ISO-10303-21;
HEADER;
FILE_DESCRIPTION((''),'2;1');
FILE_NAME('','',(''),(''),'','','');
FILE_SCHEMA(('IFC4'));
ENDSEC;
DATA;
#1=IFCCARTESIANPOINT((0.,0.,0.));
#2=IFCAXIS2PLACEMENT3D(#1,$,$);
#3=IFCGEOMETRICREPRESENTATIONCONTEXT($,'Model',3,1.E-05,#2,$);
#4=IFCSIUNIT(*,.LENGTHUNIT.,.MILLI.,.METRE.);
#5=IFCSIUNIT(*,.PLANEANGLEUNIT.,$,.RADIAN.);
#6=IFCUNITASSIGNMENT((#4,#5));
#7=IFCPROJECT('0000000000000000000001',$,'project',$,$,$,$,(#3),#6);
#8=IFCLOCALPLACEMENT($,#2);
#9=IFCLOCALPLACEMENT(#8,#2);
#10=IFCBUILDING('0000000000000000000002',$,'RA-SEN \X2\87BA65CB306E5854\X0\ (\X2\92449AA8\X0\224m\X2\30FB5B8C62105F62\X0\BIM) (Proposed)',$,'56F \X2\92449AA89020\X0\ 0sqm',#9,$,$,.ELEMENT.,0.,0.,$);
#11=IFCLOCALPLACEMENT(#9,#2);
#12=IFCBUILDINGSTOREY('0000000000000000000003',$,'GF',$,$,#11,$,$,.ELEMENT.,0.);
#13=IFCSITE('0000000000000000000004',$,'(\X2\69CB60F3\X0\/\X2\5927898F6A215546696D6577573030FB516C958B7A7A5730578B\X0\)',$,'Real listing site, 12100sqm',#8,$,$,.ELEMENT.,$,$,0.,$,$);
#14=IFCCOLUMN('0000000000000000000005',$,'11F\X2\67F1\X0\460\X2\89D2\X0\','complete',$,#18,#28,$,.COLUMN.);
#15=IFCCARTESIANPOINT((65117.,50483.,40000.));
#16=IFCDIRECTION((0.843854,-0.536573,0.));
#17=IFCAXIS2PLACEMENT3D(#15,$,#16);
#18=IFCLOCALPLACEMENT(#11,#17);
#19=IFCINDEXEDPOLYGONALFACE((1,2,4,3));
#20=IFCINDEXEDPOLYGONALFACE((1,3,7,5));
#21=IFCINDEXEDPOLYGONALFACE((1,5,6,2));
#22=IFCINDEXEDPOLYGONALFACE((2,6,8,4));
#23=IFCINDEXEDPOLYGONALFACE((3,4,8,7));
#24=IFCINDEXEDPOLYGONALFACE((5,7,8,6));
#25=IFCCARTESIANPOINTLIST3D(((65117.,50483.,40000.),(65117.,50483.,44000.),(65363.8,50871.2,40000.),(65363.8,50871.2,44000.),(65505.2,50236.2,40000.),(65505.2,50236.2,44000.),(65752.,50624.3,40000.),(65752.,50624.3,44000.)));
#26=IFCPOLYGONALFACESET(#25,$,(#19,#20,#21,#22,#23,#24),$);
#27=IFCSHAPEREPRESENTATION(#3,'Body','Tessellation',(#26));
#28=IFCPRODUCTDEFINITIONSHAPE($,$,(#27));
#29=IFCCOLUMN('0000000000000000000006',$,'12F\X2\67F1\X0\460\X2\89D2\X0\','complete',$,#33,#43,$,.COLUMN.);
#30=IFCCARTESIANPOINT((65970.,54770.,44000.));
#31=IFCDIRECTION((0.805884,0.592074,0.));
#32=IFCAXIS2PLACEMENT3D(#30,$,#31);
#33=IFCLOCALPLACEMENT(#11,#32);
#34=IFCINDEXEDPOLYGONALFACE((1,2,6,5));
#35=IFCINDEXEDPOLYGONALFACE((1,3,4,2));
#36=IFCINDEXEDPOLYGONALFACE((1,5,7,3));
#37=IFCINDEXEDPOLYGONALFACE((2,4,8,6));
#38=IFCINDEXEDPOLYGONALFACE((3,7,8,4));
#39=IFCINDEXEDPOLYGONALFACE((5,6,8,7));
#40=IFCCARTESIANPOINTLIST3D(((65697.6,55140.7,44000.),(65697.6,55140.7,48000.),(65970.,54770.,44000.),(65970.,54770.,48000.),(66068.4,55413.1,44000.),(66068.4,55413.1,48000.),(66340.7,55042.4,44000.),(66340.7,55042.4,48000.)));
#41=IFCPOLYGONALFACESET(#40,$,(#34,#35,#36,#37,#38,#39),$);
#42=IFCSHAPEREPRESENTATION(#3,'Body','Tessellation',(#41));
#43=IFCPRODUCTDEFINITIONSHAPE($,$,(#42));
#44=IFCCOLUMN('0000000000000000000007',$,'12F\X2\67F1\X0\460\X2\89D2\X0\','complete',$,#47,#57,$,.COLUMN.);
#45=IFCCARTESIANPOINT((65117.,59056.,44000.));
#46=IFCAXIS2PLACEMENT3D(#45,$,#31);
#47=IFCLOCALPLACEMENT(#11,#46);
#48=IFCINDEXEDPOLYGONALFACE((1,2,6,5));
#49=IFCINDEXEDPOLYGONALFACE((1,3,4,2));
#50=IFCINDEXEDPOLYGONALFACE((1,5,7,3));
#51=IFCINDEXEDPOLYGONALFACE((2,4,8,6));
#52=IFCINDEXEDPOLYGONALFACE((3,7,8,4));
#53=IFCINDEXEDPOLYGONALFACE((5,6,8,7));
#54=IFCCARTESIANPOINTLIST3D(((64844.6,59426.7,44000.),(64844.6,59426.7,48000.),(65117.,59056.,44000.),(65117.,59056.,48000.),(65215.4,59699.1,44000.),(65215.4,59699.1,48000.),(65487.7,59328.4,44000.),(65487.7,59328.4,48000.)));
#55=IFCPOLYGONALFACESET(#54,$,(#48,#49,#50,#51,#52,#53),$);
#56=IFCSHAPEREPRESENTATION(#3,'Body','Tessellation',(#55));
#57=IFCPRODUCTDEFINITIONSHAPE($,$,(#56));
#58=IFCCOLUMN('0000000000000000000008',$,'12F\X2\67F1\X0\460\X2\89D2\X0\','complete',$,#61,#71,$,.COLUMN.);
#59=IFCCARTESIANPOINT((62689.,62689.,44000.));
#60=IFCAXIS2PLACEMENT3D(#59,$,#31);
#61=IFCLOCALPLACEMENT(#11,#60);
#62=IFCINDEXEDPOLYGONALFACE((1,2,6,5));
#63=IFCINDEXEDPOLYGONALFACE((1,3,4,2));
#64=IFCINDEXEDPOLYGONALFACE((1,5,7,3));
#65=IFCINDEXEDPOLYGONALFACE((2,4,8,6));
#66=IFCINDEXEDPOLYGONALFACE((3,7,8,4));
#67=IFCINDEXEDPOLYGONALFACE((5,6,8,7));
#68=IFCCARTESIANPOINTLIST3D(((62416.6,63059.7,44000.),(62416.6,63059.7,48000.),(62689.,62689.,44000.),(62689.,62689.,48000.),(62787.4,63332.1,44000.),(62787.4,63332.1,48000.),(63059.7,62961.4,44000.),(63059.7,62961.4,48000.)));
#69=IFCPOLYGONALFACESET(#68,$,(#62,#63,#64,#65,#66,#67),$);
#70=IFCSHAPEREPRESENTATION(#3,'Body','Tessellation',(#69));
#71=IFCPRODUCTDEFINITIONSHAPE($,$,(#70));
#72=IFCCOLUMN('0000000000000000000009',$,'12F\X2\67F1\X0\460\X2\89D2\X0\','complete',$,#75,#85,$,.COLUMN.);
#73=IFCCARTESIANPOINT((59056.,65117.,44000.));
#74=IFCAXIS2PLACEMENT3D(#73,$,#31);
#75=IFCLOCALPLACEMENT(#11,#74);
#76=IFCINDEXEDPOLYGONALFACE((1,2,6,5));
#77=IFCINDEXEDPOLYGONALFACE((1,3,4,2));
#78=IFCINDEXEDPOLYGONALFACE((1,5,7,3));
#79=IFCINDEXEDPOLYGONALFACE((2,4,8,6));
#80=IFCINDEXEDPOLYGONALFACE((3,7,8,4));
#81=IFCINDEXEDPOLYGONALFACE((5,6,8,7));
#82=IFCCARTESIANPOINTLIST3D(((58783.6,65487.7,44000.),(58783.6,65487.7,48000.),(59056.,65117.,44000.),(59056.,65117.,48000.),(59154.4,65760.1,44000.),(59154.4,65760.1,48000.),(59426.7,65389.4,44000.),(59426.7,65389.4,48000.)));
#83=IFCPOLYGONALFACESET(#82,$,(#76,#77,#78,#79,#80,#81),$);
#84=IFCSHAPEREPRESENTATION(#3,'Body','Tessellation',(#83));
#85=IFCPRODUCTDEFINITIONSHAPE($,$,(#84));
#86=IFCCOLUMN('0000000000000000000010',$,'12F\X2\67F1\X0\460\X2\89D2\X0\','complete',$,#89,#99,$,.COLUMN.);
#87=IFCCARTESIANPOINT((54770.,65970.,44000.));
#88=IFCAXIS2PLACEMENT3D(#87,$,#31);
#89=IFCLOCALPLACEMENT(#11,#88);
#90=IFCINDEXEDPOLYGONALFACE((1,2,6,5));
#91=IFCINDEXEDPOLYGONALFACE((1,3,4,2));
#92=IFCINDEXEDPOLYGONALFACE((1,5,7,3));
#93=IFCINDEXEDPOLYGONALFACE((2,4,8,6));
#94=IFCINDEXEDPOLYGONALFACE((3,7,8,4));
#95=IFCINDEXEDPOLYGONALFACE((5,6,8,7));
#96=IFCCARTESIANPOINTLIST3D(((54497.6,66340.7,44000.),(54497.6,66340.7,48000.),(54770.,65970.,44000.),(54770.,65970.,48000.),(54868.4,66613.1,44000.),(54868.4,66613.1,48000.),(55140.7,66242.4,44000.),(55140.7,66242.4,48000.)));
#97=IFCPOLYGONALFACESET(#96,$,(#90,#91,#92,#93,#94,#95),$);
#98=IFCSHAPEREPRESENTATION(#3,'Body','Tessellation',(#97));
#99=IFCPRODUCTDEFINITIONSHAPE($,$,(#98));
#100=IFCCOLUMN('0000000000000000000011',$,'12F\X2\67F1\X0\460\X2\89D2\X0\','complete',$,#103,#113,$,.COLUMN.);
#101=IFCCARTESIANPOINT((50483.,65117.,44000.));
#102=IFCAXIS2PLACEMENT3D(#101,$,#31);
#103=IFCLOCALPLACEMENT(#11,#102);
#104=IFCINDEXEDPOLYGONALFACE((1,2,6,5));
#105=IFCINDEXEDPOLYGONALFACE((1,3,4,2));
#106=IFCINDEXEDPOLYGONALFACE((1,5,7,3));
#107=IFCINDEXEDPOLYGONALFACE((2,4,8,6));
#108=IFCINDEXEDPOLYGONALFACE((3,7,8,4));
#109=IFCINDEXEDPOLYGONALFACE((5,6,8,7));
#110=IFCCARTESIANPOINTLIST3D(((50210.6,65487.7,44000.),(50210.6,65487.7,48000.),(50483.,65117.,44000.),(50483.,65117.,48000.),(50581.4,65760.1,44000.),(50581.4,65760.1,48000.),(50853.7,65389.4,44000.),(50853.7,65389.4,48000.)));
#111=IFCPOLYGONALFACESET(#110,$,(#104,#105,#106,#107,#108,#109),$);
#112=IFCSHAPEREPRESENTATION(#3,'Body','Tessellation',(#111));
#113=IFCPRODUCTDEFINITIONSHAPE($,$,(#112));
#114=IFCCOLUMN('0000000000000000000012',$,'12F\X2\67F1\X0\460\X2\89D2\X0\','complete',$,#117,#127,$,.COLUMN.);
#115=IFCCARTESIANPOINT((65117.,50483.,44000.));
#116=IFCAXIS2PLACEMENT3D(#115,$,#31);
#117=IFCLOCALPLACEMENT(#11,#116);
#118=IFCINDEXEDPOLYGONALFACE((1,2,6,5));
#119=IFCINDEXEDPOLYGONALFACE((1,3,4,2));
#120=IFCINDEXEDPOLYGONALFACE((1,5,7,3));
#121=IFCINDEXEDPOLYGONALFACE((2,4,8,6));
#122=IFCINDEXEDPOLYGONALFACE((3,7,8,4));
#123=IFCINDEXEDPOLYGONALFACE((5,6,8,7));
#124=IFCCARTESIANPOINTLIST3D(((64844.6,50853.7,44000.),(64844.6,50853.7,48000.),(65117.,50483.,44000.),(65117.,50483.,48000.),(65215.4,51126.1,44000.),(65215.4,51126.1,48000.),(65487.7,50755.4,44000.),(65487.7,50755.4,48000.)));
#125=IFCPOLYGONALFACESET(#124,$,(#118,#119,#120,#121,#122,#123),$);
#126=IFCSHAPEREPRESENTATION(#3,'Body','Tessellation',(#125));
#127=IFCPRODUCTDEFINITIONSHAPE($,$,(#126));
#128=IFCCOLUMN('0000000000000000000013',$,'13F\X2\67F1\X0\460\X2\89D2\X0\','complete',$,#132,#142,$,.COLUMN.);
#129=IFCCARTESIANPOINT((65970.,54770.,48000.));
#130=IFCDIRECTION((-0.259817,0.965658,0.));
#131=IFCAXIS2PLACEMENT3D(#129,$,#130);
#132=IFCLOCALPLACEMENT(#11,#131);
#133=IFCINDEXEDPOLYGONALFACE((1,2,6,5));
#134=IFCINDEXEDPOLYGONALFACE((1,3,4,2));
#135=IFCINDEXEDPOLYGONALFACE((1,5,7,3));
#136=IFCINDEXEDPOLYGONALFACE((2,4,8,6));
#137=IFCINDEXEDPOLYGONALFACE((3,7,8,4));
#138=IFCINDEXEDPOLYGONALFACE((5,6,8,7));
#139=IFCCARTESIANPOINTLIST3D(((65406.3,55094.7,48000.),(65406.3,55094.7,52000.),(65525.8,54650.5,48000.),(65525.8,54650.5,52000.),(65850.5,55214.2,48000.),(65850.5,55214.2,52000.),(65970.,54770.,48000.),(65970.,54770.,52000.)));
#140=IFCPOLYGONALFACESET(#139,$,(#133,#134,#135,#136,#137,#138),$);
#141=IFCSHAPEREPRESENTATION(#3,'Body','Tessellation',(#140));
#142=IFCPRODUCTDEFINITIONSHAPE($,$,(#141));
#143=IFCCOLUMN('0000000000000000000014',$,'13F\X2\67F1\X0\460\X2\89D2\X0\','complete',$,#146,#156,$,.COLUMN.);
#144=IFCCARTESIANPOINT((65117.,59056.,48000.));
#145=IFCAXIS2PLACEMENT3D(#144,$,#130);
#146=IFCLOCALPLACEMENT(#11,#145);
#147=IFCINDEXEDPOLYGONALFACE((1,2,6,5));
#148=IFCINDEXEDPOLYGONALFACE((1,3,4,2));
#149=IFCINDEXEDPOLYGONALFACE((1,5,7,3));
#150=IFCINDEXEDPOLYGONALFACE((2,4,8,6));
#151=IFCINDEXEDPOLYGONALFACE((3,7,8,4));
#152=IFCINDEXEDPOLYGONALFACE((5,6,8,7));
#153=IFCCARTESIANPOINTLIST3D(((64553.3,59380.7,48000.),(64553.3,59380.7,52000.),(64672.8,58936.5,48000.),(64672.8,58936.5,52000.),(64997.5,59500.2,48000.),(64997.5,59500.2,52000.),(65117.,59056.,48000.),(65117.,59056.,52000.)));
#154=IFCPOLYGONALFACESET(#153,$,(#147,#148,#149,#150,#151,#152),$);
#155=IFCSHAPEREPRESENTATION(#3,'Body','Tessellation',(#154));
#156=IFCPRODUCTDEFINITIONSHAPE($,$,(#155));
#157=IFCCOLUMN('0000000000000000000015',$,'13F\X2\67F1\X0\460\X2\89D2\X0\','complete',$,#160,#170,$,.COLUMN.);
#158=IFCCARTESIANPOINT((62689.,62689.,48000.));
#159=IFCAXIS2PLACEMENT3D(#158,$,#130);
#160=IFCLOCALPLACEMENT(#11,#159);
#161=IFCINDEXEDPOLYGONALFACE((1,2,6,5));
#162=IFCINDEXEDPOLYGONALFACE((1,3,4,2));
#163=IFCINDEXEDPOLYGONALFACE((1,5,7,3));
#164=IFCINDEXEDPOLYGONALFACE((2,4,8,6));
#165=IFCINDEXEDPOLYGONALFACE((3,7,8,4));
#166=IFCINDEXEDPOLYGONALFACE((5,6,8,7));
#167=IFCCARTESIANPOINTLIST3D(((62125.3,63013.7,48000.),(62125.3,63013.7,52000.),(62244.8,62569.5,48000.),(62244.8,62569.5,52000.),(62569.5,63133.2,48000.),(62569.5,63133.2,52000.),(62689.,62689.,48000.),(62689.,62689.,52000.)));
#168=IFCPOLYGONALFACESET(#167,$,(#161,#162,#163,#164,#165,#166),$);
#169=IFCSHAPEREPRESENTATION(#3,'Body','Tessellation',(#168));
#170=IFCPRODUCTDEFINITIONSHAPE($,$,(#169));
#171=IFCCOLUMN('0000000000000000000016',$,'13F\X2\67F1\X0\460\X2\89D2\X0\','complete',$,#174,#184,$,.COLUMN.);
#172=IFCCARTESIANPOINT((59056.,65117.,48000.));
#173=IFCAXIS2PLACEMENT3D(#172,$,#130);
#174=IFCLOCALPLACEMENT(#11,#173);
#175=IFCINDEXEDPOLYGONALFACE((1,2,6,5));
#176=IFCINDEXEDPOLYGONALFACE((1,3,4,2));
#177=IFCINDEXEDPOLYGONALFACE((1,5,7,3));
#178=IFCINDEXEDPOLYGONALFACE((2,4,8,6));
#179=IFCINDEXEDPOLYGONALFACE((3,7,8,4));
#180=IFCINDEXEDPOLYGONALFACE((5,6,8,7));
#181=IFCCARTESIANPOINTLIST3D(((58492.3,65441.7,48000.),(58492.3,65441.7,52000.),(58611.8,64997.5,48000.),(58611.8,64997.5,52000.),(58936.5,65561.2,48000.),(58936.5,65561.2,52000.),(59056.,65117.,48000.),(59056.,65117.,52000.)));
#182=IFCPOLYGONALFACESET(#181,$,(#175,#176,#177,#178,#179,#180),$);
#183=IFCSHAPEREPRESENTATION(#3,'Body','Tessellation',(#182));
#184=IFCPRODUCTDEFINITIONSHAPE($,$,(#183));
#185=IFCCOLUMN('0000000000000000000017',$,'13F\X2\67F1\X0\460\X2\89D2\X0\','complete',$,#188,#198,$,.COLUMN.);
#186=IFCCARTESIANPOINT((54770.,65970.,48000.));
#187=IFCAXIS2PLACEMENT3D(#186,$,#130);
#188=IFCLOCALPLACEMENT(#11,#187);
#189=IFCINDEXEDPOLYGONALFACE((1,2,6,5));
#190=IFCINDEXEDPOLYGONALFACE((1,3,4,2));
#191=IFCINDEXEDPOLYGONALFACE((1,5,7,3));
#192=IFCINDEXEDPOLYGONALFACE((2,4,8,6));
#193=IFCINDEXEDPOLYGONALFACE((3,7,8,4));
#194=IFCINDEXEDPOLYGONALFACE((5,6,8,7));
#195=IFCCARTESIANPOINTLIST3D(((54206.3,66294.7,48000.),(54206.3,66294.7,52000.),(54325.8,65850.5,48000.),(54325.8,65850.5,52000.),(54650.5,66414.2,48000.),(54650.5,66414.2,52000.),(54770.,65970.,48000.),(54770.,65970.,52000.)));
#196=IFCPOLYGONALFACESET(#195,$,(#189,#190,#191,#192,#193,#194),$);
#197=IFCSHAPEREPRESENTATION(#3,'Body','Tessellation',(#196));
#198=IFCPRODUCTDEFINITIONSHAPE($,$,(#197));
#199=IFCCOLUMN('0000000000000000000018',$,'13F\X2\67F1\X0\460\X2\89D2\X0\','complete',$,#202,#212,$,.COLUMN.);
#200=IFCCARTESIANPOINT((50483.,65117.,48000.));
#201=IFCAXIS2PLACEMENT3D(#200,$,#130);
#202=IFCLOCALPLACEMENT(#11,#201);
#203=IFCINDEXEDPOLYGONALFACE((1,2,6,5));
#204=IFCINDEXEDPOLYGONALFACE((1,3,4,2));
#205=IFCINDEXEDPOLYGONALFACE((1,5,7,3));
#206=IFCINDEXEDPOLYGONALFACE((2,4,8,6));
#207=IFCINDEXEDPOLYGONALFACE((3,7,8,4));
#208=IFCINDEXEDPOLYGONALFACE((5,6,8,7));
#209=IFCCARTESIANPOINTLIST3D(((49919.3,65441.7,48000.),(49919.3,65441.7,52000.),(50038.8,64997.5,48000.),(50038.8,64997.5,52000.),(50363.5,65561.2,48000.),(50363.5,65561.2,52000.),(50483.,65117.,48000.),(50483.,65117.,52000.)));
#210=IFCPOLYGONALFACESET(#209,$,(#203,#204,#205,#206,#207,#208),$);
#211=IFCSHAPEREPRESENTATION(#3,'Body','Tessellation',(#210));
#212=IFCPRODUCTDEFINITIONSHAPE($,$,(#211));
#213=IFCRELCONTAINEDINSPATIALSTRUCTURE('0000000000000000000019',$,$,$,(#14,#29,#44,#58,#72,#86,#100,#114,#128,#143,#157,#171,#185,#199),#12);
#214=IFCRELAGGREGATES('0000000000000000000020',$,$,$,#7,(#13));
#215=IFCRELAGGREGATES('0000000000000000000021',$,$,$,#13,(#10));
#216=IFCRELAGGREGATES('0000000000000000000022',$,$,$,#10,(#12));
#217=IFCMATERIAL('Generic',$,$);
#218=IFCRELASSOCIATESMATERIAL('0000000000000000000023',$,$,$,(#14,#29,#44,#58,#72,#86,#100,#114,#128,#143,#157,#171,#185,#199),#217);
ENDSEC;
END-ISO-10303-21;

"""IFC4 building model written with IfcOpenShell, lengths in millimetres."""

from ifc_helpers import new_model, si_unit, frame, frame_2d, origin, place, context, project, spatial, rectangle, extrude, material, element, save


model = new_model("IFC4")

# Units and contexts
model_context = context("Model", 3, precision=1e-05, world=origin())
ifc_project = project(units=[si_unit("LENGTHUNIT", "METRE", prefix="MILLI"), si_unit("PLANEANGLEUNIT", "RADIAN")], contexts=[model_context])

# Site, building, storey
site_placement = place(None, origin())
site = spatial("IfcSite", under=ifc_project, at=site_placement, Name="(構想/大規模商業敷地・公開空地型)", ObjectType="Real listing site, 12100sqm", CompositionType="ELEMENT", RefElevation=0.0)
building_placement = place(site_placement, origin())
building = spatial("IfcBuilding", under=site, at=building_placement, Name="RA-SEN 螺旋の塔 (鉄骨224m・完成形BIM) (Proposed)", ObjectType="56F 鉄骨造 0sqm", CompositionType="ELEMENT", ElevationOfRefHeight=0.0, ElevationOfTerrain=0.0)
storey_placement = place(building_placement, origin())
storey = spatial("IfcBuildingStorey", under=building, at=storey_placement, Name="GF", CompositionType="ELEMENT", Elevation=0.0)

# Columns
ifc_material = material(Name="Generic")
column_1_placement = place(storey_placement, frame((65117.0, 50483.0, 40000.0), x_axis=(0.843854, -0.536573, 0.0)))
element("IfcColumn", 1, at=column_1_placement, inside=storey, material=ifc_material, Name="11F柱460角", Description="complete", PredefinedType="COLUMN", context=model_context, shape_type="SweptSolid", body=[
    extrude(rectangle(XDim=460.0, YDim=460.0, at=frame_2d((230.0, 230.0))), frame((65117.0, 50483.0, 40000.0), x_axis=(0.843854, -0.536573, 0.0)), (0.0, 0.0, 1.0), 4000.0),
])
column_2_placement = place(storey_placement, frame((65970.0, 54770.0, 44000.0), x_axis=(0.805884, 0.592074, 0.0)))
element("IfcColumn", 2, at=column_2_placement, inside=storey, material=ifc_material, Name="12F柱460角", Description="complete", PredefinedType="COLUMN", context=model_context, shape_type="SweptSolid", body=[
    extrude(rectangle(XDim=460.0, YDim=460.0, at=frame_2d((230.0, 230.0))), frame((65970.0, 54770.0, 44000.0), x_axis=(0.805884, 0.592074, 0.0)), (0.0, 0.0, 1.0), 4000.0),
])
column_3_placement = place(storey_placement, frame((65117.0, 59056.0, 44000.0), x_axis=(0.805884, 0.592074, 0.0)))
element("IfcColumn", 3, at=column_3_placement, inside=storey, material=ifc_material, Name="12F柱460角", Description="complete", PredefinedType="COLUMN", context=model_context, shape_type="SweptSolid", body=[
    extrude(rectangle(XDim=460.0, YDim=460.0, at=frame_2d((230.0, 230.0))), frame((65117.0, 59056.0, 44000.0), x_axis=(0.805884, 0.592074, 0.0)), (0.0, 0.0, 1.0), 4000.0),
])
column_4_placement = place(storey_placement, frame((62689.0, 62689.0, 44000.0), x_axis=(0.805884, 0.592074, 0.0)))
element("IfcColumn", 4, at=column_4_placement, inside=storey, material=ifc_material, Name="12F柱460角", Description="complete", PredefinedType="COLUMN", context=model_context, shape_type="SweptSolid", body=[
    extrude(rectangle(XDim=460.0, YDim=460.0, at=frame_2d((230.0, 230.0))), frame((62689.0, 62689.0, 44000.0), x_axis=(0.805884, 0.592074, 0.0)), (0.0, 0.0, 1.0), 4000.0),
])
column_5_placement = place(storey_placement, frame((59056.0, 65117.0, 44000.0), x_axis=(0.805884, 0.592074, 0.0)))
element("IfcColumn", 5, at=column_5_placement, inside=storey, material=ifc_material, Name="12F柱460角", Description="complete", PredefinedType="COLUMN", context=model_context, shape_type="SweptSolid", body=[
    extrude(rectangle(XDim=460.0, YDim=460.0, at=frame_2d((230.0, 230.0))), frame((59056.0, 65117.0, 44000.0), x_axis=(0.805884, 0.592074, 0.0)), (0.0, 0.0, 1.0), 4000.0),
])
column_6_placement = place(storey_placement, frame((54770.0, 65970.0, 44000.0), x_axis=(0.805884, 0.592074, 0.0)))
element("IfcColumn", 6, at=column_6_placement, inside=storey, material=ifc_material, Name="12F柱460角", Description="complete", PredefinedType="COLUMN", context=model_context, shape_type="SweptSolid", body=[
    extrude(rectangle(XDim=460.0, YDim=460.0, at=frame_2d((230.0, 230.0))), frame((54770.0, 65970.0, 44000.0), x_axis=(0.805884, 0.592074, 0.0)), (0.0, 0.0, 1.0), 4000.0),
])
column_7_placement = place(storey_placement, frame((50483.0, 65117.0, 44000.0), x_axis=(0.805884, 0.592074, 0.0)))
element("IfcColumn", 7, at=column_7_placement, inside=storey, material=ifc_material, Name="12F柱460角", Description="complete", PredefinedType="COLUMN", context=model_context, shape_type="SweptSolid", body=[
    extrude(rectangle(XDim=460.0, YDim=460.0, at=frame_2d((230.0, 230.0))), frame((50483.0, 65117.0, 44000.0), x_axis=(0.805884, 0.592074, 0.0)), (0.0, 0.0, 1.0), 4000.0),
])
column_8_placement = place(storey_placement, frame((65117.0, 50483.0, 44000.0), x_axis=(0.805884, 0.592074, 0.0)))
element("IfcColumn", 8, at=column_8_placement, inside=storey, material=ifc_material, Name="12F柱460角", Description="complete", PredefinedType="COLUMN", context=model_context, shape_type="SweptSolid", body=[
    extrude(rectangle(XDim=460.0, YDim=460.0, at=frame_2d((230.0, 230.0))), frame((65117.0, 50483.0, 44000.0), x_axis=(0.805884, 0.592074, 0.0)), (0.0, 0.0, 1.0), 4000.0),
])
column_9_placement = place(storey_placement, frame((65970.0, 54770.0, 48000.0), x_axis=(-0.259817, 0.965658, 0.0)))
element("IfcColumn", 9, at=column_9_placement, inside=storey, material=ifc_material, Name="13F柱460角", Description="complete", PredefinedType="COLUMN", context=model_context, shape_type="SweptSolid", body=[
    extrude(rectangle(XDim=460.0, YDim=460.0, at=frame_2d((230.0, 230.0))), frame((65970.0, 54770.0, 48000.0), x_axis=(-0.259817, 0.965658, 0.0)), (0.0, 0.0, 1.0), 4000.0),
])
column_10_placement = place(storey_placement, frame((65117.0, 59056.0, 48000.0), x_axis=(-0.259817, 0.965658, 0.0)))
element("IfcColumn", 10, at=column_10_placement, inside=storey, material=ifc_material, Name="13F柱460角", Description="complete", PredefinedType="COLUMN", context=model_context, shape_type="SweptSolid", body=[
    extrude(rectangle(XDim=460.0, YDim=460.0, at=frame_2d((230.0, 230.0))), frame((65117.0, 59056.0, 48000.0), x_axis=(-0.259817, 0.965658, 0.0)), (0.0, 0.0, 1.0), 4000.0),
])
column_11_placement = place(storey_placement, frame((62689.0, 62689.0, 48000.0), x_axis=(-0.259817, 0.965658, 0.0)))
element("IfcColumn", 11, at=column_11_placement, inside=storey, material=ifc_material, Name="13F柱460角", Description="complete", PredefinedType="COLUMN", context=model_context, shape_type="SweptSolid", body=[
    extrude(rectangle(XDim=460.0, YDim=460.0, at=frame_2d((230.0, 230.0))), frame((62689.0, 62689.0, 48000.0), x_axis=(-0.259817, 0.965658, 0.0)), (0.0, 0.0, 1.0), 4000.0),
])
column_12_placement = place(storey_placement, frame((59056.0, 65117.0, 48000.0), x_axis=(-0.259817, 0.965658, 0.0)))
element("IfcColumn", 12, at=column_12_placement, inside=storey, material=ifc_material, Name="13F柱460角", Description="complete", PredefinedType="COLUMN", context=model_context, shape_type="SweptSolid", body=[
    extrude(rectangle(XDim=460.0, YDim=460.0, at=frame_2d((230.0, 230.0))), frame((59056.0, 65117.0, 48000.0), x_axis=(-0.259817, 0.965658, 0.0)), (0.0, 0.0, 1.0), 4000.0),
])
column_13_placement = place(storey_placement, frame((54770.0, 65970.0, 48000.0), x_axis=(-0.259817, 0.965658, 0.0)))
element("IfcColumn", 13, at=column_13_placement, inside=storey, material=ifc_material, Name="13F柱460角", Description="complete", PredefinedType="COLUMN", context=model_context, shape_type="SweptSolid", body=[
    extrude(rectangle(XDim=460.0, YDim=460.0, at=frame_2d((230.0, 230.0))), frame((54770.0, 65970.0, 48000.0), x_axis=(-0.259817, 0.965658, 0.0)), (0.0, 0.0, 1.0), 4000.0),
])
column_14_placement = place(storey_placement, frame((50483.0, 65117.0, 48000.0), x_axis=(-0.259817, 0.965658, 0.0)))
element("IfcColumn", 14, at=column_14_placement, inside=storey, material=ifc_material, Name="13F柱460角", Description="complete", PredefinedType="COLUMN", context=model_context, shape_type="SweptSolid", body=[
    extrude(rectangle(XDim=460.0, YDim=460.0, at=frame_2d((230.0, 230.0))), frame((50483.0, 65117.0, 48000.0), x_axis=(-0.259817, 0.965658, 0.0)), (0.0, 0.0, 1.0), 4000.0),
])

save(model, "model.ifc")
